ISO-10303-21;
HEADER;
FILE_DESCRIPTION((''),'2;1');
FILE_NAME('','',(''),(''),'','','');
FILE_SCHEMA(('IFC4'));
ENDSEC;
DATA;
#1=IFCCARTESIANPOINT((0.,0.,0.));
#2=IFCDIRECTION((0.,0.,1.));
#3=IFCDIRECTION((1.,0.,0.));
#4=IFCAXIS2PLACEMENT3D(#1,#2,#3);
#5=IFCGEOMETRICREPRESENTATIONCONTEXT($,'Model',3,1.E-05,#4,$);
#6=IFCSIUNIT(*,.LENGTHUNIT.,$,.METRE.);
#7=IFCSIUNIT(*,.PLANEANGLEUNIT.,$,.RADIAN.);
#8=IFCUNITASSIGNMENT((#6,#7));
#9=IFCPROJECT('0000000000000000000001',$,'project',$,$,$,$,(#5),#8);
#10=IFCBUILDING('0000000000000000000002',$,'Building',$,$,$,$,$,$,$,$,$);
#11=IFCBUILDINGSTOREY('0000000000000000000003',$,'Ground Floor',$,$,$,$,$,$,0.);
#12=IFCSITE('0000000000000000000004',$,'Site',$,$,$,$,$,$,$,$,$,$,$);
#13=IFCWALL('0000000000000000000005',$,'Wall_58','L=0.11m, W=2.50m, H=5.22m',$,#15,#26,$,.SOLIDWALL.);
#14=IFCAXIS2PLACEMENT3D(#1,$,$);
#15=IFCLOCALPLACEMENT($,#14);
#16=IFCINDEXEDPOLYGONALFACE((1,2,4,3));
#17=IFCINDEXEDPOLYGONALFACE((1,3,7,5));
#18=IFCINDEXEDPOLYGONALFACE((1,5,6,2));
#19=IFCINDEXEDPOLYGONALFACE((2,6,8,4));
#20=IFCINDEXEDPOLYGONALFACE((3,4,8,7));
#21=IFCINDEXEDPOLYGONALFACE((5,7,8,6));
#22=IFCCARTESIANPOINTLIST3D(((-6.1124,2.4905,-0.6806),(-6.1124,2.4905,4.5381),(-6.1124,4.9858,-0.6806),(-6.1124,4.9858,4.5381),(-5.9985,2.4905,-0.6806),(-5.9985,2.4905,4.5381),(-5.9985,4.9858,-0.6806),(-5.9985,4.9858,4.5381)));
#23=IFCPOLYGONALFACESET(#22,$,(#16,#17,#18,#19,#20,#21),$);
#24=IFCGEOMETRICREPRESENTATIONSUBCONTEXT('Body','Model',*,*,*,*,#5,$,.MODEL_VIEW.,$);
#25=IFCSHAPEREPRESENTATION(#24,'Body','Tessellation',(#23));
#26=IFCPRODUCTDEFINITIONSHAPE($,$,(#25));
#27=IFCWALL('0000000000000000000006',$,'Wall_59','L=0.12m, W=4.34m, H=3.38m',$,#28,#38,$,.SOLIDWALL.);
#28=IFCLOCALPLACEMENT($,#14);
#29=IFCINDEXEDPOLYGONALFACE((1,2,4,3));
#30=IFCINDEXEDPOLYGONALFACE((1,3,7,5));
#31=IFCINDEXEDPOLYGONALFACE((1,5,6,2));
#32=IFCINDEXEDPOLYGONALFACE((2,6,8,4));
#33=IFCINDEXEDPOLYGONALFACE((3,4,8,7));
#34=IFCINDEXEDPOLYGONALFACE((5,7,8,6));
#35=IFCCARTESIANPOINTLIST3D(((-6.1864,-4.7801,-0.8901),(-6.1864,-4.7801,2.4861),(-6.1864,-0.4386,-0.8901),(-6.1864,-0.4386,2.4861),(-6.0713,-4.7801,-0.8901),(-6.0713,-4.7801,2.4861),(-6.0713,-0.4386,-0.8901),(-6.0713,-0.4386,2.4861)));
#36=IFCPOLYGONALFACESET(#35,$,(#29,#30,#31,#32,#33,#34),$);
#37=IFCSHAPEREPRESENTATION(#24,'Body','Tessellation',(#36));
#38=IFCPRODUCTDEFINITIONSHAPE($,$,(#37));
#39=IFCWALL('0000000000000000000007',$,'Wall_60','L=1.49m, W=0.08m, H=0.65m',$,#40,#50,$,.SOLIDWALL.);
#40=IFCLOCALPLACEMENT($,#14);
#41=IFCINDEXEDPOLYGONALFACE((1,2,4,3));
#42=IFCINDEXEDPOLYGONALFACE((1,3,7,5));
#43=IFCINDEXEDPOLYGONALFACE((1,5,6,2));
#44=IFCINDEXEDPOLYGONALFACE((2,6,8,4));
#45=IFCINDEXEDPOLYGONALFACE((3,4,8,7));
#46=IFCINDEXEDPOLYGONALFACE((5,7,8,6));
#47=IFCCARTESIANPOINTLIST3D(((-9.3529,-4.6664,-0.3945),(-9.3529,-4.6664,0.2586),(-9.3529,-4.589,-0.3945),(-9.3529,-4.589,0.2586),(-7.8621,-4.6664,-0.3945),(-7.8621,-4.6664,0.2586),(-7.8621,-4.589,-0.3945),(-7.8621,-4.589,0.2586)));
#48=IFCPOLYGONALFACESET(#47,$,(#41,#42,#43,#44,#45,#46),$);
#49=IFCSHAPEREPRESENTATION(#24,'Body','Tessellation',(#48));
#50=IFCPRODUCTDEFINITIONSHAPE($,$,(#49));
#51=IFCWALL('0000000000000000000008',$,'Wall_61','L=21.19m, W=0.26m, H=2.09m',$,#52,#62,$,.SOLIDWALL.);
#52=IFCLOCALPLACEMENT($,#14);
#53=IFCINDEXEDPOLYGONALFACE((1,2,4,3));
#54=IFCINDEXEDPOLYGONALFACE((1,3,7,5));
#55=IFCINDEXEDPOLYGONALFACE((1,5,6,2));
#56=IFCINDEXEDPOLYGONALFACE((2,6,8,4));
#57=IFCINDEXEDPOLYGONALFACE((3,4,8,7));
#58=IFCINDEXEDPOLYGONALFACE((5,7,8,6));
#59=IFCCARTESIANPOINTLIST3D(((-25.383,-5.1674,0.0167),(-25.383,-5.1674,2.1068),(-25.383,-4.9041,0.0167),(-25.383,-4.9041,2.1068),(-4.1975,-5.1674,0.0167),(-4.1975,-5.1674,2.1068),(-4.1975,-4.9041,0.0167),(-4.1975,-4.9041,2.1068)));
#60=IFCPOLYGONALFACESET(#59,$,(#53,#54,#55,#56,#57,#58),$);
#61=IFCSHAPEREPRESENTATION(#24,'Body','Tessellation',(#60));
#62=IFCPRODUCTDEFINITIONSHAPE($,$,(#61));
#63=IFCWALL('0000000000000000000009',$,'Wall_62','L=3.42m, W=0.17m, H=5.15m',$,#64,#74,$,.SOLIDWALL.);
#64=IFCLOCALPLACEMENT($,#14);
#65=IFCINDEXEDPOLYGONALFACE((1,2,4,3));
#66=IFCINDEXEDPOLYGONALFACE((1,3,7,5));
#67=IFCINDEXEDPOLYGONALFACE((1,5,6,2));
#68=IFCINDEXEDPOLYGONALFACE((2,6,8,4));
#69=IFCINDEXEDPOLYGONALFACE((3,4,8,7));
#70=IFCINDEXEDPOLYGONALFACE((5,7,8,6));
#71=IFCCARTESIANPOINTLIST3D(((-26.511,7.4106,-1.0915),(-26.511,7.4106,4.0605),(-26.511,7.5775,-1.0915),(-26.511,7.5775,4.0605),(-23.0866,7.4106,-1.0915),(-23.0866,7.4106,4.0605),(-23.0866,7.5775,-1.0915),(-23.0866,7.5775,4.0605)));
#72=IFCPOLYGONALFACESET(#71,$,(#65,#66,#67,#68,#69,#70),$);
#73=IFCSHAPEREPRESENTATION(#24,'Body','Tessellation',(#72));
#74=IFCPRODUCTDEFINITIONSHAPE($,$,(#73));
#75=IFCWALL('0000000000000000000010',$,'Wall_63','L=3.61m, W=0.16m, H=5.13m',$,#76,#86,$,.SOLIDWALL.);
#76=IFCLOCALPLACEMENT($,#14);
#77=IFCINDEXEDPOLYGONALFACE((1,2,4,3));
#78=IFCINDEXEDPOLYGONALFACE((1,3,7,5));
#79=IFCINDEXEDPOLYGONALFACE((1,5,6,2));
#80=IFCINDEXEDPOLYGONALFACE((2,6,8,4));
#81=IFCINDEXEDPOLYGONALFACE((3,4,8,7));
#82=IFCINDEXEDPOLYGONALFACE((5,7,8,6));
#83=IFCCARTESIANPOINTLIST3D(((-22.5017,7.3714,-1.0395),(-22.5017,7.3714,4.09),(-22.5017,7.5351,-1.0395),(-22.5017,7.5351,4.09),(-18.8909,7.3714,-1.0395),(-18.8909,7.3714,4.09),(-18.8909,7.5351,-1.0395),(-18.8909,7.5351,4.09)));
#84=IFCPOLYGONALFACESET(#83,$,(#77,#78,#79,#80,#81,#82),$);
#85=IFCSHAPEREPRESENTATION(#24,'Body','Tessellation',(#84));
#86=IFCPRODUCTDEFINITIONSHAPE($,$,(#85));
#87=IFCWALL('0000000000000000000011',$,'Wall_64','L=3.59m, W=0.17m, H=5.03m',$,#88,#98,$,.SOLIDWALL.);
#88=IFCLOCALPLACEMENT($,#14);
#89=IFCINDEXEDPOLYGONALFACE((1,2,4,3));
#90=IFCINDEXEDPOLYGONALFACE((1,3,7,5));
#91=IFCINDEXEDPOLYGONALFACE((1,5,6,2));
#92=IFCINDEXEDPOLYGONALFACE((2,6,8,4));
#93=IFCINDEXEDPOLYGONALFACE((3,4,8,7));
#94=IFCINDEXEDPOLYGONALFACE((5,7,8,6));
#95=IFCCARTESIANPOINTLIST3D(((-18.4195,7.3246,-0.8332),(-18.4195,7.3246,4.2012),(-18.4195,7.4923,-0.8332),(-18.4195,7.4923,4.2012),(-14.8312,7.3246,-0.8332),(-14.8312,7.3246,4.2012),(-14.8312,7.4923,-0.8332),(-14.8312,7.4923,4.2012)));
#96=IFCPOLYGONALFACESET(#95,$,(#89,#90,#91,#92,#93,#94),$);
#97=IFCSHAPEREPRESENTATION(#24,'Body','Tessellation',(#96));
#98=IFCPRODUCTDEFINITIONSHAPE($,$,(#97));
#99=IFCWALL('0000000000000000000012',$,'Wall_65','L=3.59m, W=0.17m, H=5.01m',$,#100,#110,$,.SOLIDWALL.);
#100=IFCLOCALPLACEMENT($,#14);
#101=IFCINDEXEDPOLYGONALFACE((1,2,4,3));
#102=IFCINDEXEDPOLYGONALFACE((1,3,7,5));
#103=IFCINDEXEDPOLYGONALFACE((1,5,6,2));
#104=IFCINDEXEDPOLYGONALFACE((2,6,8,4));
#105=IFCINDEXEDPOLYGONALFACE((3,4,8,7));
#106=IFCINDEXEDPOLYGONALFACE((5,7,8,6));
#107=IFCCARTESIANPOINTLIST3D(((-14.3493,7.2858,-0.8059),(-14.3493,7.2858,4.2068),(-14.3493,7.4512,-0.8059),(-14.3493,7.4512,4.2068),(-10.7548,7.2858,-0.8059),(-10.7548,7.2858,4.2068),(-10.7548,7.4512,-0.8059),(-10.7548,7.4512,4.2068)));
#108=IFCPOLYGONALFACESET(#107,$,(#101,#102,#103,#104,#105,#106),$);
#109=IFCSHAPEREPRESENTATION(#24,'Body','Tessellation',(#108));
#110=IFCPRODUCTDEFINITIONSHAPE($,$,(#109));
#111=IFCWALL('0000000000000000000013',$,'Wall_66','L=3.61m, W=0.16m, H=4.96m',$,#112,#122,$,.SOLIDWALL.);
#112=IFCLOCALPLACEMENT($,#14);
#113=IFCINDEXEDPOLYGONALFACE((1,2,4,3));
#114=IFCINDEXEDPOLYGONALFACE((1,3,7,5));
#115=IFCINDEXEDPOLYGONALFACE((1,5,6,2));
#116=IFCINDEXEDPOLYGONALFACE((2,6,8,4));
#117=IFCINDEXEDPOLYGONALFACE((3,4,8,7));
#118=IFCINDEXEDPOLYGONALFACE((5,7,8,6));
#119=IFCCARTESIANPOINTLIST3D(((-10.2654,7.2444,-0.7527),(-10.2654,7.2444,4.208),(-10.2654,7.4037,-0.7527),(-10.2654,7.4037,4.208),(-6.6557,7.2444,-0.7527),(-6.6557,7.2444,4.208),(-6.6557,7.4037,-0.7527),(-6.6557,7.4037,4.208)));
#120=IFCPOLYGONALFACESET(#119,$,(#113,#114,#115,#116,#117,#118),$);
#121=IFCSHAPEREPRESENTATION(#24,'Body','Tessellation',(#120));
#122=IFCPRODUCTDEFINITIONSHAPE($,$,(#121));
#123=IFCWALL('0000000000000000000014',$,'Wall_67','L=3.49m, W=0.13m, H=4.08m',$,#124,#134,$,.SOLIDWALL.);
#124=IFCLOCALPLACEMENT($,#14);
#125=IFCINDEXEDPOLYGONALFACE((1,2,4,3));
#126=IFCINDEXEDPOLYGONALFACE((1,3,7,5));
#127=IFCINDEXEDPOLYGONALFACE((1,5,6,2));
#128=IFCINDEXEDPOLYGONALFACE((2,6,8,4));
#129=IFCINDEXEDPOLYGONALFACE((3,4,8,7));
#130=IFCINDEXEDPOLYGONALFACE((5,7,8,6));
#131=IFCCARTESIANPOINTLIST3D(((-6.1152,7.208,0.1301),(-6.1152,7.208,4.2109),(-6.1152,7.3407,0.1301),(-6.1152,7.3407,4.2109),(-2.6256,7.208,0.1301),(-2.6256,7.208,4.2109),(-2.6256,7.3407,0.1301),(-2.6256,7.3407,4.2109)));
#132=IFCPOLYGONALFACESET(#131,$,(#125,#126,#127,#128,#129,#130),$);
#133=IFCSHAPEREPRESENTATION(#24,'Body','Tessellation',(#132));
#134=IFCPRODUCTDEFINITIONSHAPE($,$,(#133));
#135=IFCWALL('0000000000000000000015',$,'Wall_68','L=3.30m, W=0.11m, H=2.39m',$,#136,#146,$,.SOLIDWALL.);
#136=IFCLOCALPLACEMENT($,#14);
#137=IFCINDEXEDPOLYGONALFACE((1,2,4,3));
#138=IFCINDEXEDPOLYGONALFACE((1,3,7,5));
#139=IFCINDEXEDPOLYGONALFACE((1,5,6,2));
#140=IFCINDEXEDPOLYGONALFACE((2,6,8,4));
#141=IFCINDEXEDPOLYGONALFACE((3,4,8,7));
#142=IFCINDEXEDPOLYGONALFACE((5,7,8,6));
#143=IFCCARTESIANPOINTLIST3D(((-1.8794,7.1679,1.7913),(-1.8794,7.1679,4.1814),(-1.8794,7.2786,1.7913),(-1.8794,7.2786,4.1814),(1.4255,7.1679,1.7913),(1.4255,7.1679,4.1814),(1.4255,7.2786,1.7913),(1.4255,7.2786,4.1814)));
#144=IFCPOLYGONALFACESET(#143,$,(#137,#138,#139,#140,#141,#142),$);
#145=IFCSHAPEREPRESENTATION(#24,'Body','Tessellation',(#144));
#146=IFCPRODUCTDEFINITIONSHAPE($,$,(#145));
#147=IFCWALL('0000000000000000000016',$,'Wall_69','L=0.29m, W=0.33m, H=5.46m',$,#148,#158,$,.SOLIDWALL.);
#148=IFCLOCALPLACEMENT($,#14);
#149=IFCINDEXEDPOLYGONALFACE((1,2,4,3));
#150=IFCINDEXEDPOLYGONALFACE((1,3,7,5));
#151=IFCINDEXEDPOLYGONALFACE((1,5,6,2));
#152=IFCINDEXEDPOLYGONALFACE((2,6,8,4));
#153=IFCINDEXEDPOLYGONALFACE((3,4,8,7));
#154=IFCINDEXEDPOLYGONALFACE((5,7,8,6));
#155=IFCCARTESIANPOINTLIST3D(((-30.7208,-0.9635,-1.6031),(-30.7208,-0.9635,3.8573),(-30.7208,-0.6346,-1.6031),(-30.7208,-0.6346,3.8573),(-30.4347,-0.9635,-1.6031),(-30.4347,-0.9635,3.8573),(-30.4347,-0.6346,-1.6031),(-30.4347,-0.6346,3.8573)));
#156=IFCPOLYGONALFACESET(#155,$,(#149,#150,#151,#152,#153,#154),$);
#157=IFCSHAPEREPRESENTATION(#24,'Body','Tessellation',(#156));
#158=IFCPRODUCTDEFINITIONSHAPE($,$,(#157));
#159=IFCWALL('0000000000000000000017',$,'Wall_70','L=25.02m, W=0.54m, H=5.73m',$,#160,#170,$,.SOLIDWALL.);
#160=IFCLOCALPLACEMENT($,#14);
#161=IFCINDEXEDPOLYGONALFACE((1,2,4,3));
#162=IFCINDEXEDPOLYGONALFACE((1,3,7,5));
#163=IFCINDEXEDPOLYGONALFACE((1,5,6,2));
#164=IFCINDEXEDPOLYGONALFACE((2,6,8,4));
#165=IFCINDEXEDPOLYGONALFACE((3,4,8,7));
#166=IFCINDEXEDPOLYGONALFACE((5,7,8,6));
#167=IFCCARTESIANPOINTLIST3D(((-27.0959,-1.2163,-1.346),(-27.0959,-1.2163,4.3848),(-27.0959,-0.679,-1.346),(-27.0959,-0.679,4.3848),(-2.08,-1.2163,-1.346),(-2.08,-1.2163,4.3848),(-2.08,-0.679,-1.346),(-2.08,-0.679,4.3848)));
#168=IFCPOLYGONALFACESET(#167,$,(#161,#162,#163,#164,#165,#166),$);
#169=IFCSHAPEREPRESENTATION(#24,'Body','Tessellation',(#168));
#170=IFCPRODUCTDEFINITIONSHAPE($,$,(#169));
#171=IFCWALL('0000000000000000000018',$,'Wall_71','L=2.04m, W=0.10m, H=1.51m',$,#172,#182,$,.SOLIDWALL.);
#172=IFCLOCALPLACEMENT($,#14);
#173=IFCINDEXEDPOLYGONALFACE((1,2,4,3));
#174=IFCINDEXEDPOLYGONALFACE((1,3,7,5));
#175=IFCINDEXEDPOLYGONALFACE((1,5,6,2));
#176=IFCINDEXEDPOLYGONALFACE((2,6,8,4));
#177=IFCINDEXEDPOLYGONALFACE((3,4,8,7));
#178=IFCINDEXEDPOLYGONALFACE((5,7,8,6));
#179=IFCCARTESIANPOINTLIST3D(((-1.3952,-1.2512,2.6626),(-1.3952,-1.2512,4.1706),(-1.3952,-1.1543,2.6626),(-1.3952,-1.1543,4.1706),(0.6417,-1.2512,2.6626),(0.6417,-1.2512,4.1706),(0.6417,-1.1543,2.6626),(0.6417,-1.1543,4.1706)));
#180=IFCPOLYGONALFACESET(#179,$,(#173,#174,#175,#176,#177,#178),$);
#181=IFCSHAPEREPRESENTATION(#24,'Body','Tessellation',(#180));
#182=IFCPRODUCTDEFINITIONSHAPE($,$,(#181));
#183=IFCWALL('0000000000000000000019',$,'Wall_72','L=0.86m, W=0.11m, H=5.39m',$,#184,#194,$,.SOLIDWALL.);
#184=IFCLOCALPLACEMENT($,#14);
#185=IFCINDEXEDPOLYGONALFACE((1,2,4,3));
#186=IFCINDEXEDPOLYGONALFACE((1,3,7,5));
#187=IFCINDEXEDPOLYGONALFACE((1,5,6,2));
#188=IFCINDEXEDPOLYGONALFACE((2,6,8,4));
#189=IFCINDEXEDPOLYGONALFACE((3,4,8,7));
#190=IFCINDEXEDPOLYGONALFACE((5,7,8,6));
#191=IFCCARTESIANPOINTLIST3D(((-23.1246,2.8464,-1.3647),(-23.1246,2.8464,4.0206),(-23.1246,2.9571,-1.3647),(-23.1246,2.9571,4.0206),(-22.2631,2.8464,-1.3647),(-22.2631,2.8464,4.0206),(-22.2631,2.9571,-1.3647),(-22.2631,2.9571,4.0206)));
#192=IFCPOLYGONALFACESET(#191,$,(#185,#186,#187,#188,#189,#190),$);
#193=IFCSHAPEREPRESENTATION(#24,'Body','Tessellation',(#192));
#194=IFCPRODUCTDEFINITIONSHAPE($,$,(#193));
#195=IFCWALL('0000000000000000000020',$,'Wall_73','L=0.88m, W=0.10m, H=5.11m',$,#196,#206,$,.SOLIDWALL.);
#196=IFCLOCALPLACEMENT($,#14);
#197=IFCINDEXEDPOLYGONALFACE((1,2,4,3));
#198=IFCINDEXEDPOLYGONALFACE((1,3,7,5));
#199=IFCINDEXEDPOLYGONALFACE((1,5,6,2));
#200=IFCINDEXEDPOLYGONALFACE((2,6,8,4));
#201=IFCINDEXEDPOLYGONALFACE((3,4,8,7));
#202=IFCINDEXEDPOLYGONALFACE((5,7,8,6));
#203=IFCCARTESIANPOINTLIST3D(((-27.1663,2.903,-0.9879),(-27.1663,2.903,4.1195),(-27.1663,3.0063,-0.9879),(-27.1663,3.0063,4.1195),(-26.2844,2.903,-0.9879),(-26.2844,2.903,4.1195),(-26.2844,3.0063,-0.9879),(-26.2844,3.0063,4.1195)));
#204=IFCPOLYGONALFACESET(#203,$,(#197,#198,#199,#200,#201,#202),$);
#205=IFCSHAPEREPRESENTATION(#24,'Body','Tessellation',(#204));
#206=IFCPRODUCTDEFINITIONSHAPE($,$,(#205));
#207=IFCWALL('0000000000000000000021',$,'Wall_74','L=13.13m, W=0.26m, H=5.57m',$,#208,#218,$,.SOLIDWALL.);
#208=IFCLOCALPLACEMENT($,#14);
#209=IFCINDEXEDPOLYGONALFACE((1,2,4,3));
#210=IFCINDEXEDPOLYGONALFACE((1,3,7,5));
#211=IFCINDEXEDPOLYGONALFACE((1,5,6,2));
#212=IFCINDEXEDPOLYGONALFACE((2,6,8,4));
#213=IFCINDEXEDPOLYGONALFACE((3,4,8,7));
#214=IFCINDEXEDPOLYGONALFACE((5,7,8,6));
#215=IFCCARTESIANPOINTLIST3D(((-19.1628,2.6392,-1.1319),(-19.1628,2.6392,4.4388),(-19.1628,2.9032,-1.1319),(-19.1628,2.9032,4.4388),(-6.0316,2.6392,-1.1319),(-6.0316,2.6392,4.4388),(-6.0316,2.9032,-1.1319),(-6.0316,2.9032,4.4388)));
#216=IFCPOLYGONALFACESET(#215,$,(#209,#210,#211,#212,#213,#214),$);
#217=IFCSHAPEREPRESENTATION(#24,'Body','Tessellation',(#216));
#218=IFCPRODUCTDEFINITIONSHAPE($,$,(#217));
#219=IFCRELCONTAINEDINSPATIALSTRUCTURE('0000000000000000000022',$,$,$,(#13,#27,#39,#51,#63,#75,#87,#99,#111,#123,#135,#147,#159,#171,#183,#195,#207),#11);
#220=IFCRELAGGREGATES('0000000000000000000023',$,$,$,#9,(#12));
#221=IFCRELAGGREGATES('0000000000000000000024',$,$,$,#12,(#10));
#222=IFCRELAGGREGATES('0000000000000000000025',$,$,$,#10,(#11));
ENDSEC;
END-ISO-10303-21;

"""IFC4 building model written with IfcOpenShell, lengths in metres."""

from ifc_helpers import new_model, si_unit, frame, origin_with_axes, origin_2d, context, subcontext, project, spatial, rectangle, extrude, element, save


model = new_model("IFC4")

# Units and contexts
model_context = context("Model", 3, precision=1e-05, world=origin_with_axes())
body_context = subcontext(model_context, "Body", "Model", "MODEL_VIEW")
ifc_project = project(units=[si_unit("LENGTHUNIT", "METRE"), si_unit("PLANEANGLEUNIT", "RADIAN")], contexts=[model_context])

# Site, building, storey
site = spatial("IfcSite", under=ifc_project, Name="Site")
building = spatial("IfcBuilding", under=site, Name="Building")
storey = spatial("IfcBuildingStorey", under=building, Name="Ground Floor", Elevation=0.0)

# Walls
element("IfcWall", 1, inside=storey, Name="Wall_58", Description="L=0.11m, W=2.50m, H=5.22m", PredefinedType="SOLIDWALL", context=body_context, shape_type="SweptSolid", body=[
    extrude(rectangle(XDim=0.114, YDim=2.4953, at=origin_2d()), frame((-6.0555, 3.7382, -0.6806), z_axis=(0.0, 0.0, 1.0), x_axis=(1.0, 0.0, 0.0)), (0.0, 0.0, 1.0), 5.2186),
])
element("IfcWall", 2, inside=storey, Name="Wall_59", Description="L=0.12m, W=4.34m, H=3.38m", PredefinedType="SOLIDWALL", context=body_context, shape_type="SweptSolid", body=[
    extrude(rectangle(XDim=0.1151, YDim=4.3415, at=origin_2d()), frame((-6.1289, -2.6094, -0.8901), z_axis=(0.0, 0.0, 1.0), x_axis=(1.0, 0.0, 0.0)), (0.0, 0.0, 1.0), 3.3762),
])
element("IfcWall", 3, inside=storey, Name="Wall_60", Description="L=1.49m, W=0.08m, H=0.65m", PredefinedType="SOLIDWALL", context=body_context, shape_type="SweptSolid", body=[
    extrude(rectangle(XDim=1.4908, YDim=0.0774, at=origin_2d()), frame((-8.6075, -4.6277, -0.3945), z_axis=(0.0, 0.0, 1.0), x_axis=(1.0, 0.0, 0.0)), (0.0, 0.0, 1.0), 0.6531),
])
element("IfcWall", 4, inside=storey, Name="Wall_61", Description="L=21.19m, W=0.26m, H=2.09m", PredefinedType="SOLIDWALL", context=body_context, shape_type="SweptSolid", body=[
    extrude(rectangle(XDim=21.1854, YDim=0.2632, at=origin_2d()), frame((-14.7902, -5.0357, 0.0167), z_axis=(0.0, 0.0, 1.0), x_axis=(1.0, 0.0, 0.0)), (0.0, 0.0, 1.0), 2.0901),
])
element("IfcWall", 5, inside=storey, Name="Wall_62", Description="L=3.42m, W=0.17m, H=5.15m", PredefinedType="SOLIDWALL", context=body_context, shape_type="SweptSolid", body=[
    extrude(rectangle(XDim=3.4244, YDim=0.1669, at=origin_2d()), frame((-24.7988, 7.494, -1.0915), z_axis=(0.0, 0.0, 1.0), x_axis=(1.0, 0.0, 0.0)), (0.0, 0.0, 1.0), 5.152),
])
element("IfcWall", 6, inside=storey, Name="Wall_63", Description="L=3.61m, W=0.16m, H=5.13m", PredefinedType="SOLIDWALL", context=body_context, shape_type="SweptSolid", body=[
    extrude(rectangle(XDim=3.6108, YDim=0.1637, at=origin_2d()), frame((-20.6963, 7.4533, -1.0395), z_axis=(0.0, 0.0, 1.0), x_axis=(1.0, 0.0, 0.0)), (0.0, 0.0, 1.0), 5.1295),
])
element("IfcWall", 7, inside=storey, Name="Wall_64", Description="L=3.59m, W=0.17m, H=5.03m", PredefinedType="SOLIDWALL", context=body_context, shape_type="SweptSolid", body=[
    extrude(rectangle(XDim=3.5883, YDim=0.1677, at=origin_2d()), frame((-16.6253, 7.4085, -0.8332), z_axis=(0.0, 0.0, 1.0), x_axis=(1.0, 0.0, 0.0)), (0.0, 0.0, 1.0), 5.0343),
])
element("IfcWall", 8, inside=storey, Name="Wall_65", Description="L=3.59m, W=0.17m, H=5.01m", PredefinedType="SOLIDWALL", context=body_context, shape_type="SweptSolid", body=[
    extrude(rectangle(XDim=3.5945, YDim=0.1655, at=origin_2d()), frame((-12.552, 7.3685, -0.8059), z_axis=(0.0, 0.0, 1.0), x_axis=(1.0, 0.0, 0.0)), (0.0, 0.0, 1.0), 5.0127),
])
element("IfcWall", 9, inside=storey, Name="Wall_66", Description="L=3.61m, W=0.16m, H=4.96m", PredefinedType="SOLIDWALL", context=body_context, shape_type="SweptSolid", body=[
    extrude(rectangle(XDim=3.6097, YDim=0.1593, at=origin_2d()), frame((-8.4605, 7.324, -0.7527), z_axis=(0.0, 0.0, 1.0), x_axis=(1.0, 0.0, 0.0)), (0.0, 0.0, 1.0), 4.9606),
])
element("IfcWall", 10, inside=storey, Name="Wall_67", Description="L=3.49m, W=0.13m, H=4.08m", PredefinedType="SOLIDWALL", context=body_context, shape_type="SweptSolid", body=[
    extrude(rectangle(XDim=3.4897, YDim=0.1327, at=origin_2d()), frame((-4.3704, 7.2743, 0.1301), z_axis=(0.0, 0.0, 1.0), x_axis=(1.0, 0.0, 0.0)), (0.0, 0.0, 1.0), 4.0809),
])
element("IfcWall", 11, inside=storey, Name="Wall_68", Description="L=3.30m, W=0.11m, H=2.39m", PredefinedType="SOLIDWALL", context=body_context, shape_type="SweptSolid", body=[
    extrude(rectangle(XDim=3.305, YDim=0.1107, at=origin_2d()), frame((-0.227, 7.2232, 1.7913), z_axis=(0.0, 0.0, 1.0), x_axis=(1.0, 0.0, 0.0)), (0.0, 0.0, 1.0), 2.3901),
])
element("IfcWall", 12, inside=storey, Name="Wall_69", Description="L=0.29m, W=0.33m, H=5.46m", PredefinedType="SOLIDWALL", context=body_context, shape_type="SweptSolid", body=[
    extrude(rectangle(XDim=0.2861, YDim=0.3289, at=origin_2d()), frame((-30.5778, -0.799, -1.6031), z_axis=(0.0, 0.0, 1.0), x_axis=(1.0, 0.0, 0.0)), (0.0, 0.0, 1.0), 5.4605),
])
element("IfcWall", 13, inside=storey, Name="Wall_70", Description="L=25.02m, W=0.54m, H=5.73m", PredefinedType="SOLIDWALL", context=body_context, shape_type="SweptSolid", body=[
    extrude(rectangle(XDim=25.0159, YDim=0.5374, at=origin_2d()), frame((-14.5879, -0.9476, -1.346), z_axis=(0.0, 0.0, 1.0), x_axis=(1.0, 0.0, 0.0)), (0.0, 0.0, 1.0), 5.7308),
])
element("IfcWall", 14, inside=storey, Name="Wall_71", Description="L=2.04m, W=0.10m, H=1.51m", PredefinedType="SOLIDWALL", context=body_context, shape_type="SweptSolid", body=[
    extrude(rectangle(XDim=2.037, YDim=0.097, at=origin_2d()), frame((-0.3768, -1.2027, 2.6626), z_axis=(0.0, 0.0, 1.0), x_axis=(1.0, 0.0, 0.0)), (0.0, 0.0, 1.0), 1.5081),
])
element("IfcWall", 15, inside=storey, Name="Wall_72", Description="L=0.86m, W=0.11m, H=5.39m", PredefinedType="SOLIDWALL", context=body_context, shape_type="SweptSolid", body=[
    extrude(rectangle(XDim=0.8615, YDim=0.1107, at=origin_2d()), frame((-22.6939, 2.9017, -1.3647), z_axis=(0.0, 0.0, 1.0), x_axis=(1.0, 0.0, 0.0)), (0.0, 0.0, 1.0), 5.3853),
])
element("IfcWall", 16, inside=storey, Name="Wall_73", Description="L=0.88m, W=0.10m, H=5.11m", PredefinedType="SOLIDWALL", context=body_context, shape_type="SweptSolid", body=[
    extrude(rectangle(XDim=0.8819, YDim=0.1033, at=origin_2d()), frame((-26.7254, 2.9547, -0.9879), z_axis=(0.0, 0.0, 1.0), x_axis=(1.0, 0.0, 0.0)), (0.0, 0.0, 1.0), 5.1075),
])
element("IfcWall", 17, inside=storey, Name="Wall_74", Description="L=13.13m, W=0.26m, H=5.57m", PredefinedType="SOLIDWALL", context=body_context, shape_type="SweptSolid", body=[
    extrude(rectangle(XDim=13.1312, YDim=0.264, at=origin_2d()), frame((-12.5972, 2.7712, -1.1319), z_axis=(0.0, 0.0, 1.0), x_axis=(1.0, 0.0, 0.0)), (0.0, 0.0, 1.0), 5.5707),
])

save(model, "model.ifc")
